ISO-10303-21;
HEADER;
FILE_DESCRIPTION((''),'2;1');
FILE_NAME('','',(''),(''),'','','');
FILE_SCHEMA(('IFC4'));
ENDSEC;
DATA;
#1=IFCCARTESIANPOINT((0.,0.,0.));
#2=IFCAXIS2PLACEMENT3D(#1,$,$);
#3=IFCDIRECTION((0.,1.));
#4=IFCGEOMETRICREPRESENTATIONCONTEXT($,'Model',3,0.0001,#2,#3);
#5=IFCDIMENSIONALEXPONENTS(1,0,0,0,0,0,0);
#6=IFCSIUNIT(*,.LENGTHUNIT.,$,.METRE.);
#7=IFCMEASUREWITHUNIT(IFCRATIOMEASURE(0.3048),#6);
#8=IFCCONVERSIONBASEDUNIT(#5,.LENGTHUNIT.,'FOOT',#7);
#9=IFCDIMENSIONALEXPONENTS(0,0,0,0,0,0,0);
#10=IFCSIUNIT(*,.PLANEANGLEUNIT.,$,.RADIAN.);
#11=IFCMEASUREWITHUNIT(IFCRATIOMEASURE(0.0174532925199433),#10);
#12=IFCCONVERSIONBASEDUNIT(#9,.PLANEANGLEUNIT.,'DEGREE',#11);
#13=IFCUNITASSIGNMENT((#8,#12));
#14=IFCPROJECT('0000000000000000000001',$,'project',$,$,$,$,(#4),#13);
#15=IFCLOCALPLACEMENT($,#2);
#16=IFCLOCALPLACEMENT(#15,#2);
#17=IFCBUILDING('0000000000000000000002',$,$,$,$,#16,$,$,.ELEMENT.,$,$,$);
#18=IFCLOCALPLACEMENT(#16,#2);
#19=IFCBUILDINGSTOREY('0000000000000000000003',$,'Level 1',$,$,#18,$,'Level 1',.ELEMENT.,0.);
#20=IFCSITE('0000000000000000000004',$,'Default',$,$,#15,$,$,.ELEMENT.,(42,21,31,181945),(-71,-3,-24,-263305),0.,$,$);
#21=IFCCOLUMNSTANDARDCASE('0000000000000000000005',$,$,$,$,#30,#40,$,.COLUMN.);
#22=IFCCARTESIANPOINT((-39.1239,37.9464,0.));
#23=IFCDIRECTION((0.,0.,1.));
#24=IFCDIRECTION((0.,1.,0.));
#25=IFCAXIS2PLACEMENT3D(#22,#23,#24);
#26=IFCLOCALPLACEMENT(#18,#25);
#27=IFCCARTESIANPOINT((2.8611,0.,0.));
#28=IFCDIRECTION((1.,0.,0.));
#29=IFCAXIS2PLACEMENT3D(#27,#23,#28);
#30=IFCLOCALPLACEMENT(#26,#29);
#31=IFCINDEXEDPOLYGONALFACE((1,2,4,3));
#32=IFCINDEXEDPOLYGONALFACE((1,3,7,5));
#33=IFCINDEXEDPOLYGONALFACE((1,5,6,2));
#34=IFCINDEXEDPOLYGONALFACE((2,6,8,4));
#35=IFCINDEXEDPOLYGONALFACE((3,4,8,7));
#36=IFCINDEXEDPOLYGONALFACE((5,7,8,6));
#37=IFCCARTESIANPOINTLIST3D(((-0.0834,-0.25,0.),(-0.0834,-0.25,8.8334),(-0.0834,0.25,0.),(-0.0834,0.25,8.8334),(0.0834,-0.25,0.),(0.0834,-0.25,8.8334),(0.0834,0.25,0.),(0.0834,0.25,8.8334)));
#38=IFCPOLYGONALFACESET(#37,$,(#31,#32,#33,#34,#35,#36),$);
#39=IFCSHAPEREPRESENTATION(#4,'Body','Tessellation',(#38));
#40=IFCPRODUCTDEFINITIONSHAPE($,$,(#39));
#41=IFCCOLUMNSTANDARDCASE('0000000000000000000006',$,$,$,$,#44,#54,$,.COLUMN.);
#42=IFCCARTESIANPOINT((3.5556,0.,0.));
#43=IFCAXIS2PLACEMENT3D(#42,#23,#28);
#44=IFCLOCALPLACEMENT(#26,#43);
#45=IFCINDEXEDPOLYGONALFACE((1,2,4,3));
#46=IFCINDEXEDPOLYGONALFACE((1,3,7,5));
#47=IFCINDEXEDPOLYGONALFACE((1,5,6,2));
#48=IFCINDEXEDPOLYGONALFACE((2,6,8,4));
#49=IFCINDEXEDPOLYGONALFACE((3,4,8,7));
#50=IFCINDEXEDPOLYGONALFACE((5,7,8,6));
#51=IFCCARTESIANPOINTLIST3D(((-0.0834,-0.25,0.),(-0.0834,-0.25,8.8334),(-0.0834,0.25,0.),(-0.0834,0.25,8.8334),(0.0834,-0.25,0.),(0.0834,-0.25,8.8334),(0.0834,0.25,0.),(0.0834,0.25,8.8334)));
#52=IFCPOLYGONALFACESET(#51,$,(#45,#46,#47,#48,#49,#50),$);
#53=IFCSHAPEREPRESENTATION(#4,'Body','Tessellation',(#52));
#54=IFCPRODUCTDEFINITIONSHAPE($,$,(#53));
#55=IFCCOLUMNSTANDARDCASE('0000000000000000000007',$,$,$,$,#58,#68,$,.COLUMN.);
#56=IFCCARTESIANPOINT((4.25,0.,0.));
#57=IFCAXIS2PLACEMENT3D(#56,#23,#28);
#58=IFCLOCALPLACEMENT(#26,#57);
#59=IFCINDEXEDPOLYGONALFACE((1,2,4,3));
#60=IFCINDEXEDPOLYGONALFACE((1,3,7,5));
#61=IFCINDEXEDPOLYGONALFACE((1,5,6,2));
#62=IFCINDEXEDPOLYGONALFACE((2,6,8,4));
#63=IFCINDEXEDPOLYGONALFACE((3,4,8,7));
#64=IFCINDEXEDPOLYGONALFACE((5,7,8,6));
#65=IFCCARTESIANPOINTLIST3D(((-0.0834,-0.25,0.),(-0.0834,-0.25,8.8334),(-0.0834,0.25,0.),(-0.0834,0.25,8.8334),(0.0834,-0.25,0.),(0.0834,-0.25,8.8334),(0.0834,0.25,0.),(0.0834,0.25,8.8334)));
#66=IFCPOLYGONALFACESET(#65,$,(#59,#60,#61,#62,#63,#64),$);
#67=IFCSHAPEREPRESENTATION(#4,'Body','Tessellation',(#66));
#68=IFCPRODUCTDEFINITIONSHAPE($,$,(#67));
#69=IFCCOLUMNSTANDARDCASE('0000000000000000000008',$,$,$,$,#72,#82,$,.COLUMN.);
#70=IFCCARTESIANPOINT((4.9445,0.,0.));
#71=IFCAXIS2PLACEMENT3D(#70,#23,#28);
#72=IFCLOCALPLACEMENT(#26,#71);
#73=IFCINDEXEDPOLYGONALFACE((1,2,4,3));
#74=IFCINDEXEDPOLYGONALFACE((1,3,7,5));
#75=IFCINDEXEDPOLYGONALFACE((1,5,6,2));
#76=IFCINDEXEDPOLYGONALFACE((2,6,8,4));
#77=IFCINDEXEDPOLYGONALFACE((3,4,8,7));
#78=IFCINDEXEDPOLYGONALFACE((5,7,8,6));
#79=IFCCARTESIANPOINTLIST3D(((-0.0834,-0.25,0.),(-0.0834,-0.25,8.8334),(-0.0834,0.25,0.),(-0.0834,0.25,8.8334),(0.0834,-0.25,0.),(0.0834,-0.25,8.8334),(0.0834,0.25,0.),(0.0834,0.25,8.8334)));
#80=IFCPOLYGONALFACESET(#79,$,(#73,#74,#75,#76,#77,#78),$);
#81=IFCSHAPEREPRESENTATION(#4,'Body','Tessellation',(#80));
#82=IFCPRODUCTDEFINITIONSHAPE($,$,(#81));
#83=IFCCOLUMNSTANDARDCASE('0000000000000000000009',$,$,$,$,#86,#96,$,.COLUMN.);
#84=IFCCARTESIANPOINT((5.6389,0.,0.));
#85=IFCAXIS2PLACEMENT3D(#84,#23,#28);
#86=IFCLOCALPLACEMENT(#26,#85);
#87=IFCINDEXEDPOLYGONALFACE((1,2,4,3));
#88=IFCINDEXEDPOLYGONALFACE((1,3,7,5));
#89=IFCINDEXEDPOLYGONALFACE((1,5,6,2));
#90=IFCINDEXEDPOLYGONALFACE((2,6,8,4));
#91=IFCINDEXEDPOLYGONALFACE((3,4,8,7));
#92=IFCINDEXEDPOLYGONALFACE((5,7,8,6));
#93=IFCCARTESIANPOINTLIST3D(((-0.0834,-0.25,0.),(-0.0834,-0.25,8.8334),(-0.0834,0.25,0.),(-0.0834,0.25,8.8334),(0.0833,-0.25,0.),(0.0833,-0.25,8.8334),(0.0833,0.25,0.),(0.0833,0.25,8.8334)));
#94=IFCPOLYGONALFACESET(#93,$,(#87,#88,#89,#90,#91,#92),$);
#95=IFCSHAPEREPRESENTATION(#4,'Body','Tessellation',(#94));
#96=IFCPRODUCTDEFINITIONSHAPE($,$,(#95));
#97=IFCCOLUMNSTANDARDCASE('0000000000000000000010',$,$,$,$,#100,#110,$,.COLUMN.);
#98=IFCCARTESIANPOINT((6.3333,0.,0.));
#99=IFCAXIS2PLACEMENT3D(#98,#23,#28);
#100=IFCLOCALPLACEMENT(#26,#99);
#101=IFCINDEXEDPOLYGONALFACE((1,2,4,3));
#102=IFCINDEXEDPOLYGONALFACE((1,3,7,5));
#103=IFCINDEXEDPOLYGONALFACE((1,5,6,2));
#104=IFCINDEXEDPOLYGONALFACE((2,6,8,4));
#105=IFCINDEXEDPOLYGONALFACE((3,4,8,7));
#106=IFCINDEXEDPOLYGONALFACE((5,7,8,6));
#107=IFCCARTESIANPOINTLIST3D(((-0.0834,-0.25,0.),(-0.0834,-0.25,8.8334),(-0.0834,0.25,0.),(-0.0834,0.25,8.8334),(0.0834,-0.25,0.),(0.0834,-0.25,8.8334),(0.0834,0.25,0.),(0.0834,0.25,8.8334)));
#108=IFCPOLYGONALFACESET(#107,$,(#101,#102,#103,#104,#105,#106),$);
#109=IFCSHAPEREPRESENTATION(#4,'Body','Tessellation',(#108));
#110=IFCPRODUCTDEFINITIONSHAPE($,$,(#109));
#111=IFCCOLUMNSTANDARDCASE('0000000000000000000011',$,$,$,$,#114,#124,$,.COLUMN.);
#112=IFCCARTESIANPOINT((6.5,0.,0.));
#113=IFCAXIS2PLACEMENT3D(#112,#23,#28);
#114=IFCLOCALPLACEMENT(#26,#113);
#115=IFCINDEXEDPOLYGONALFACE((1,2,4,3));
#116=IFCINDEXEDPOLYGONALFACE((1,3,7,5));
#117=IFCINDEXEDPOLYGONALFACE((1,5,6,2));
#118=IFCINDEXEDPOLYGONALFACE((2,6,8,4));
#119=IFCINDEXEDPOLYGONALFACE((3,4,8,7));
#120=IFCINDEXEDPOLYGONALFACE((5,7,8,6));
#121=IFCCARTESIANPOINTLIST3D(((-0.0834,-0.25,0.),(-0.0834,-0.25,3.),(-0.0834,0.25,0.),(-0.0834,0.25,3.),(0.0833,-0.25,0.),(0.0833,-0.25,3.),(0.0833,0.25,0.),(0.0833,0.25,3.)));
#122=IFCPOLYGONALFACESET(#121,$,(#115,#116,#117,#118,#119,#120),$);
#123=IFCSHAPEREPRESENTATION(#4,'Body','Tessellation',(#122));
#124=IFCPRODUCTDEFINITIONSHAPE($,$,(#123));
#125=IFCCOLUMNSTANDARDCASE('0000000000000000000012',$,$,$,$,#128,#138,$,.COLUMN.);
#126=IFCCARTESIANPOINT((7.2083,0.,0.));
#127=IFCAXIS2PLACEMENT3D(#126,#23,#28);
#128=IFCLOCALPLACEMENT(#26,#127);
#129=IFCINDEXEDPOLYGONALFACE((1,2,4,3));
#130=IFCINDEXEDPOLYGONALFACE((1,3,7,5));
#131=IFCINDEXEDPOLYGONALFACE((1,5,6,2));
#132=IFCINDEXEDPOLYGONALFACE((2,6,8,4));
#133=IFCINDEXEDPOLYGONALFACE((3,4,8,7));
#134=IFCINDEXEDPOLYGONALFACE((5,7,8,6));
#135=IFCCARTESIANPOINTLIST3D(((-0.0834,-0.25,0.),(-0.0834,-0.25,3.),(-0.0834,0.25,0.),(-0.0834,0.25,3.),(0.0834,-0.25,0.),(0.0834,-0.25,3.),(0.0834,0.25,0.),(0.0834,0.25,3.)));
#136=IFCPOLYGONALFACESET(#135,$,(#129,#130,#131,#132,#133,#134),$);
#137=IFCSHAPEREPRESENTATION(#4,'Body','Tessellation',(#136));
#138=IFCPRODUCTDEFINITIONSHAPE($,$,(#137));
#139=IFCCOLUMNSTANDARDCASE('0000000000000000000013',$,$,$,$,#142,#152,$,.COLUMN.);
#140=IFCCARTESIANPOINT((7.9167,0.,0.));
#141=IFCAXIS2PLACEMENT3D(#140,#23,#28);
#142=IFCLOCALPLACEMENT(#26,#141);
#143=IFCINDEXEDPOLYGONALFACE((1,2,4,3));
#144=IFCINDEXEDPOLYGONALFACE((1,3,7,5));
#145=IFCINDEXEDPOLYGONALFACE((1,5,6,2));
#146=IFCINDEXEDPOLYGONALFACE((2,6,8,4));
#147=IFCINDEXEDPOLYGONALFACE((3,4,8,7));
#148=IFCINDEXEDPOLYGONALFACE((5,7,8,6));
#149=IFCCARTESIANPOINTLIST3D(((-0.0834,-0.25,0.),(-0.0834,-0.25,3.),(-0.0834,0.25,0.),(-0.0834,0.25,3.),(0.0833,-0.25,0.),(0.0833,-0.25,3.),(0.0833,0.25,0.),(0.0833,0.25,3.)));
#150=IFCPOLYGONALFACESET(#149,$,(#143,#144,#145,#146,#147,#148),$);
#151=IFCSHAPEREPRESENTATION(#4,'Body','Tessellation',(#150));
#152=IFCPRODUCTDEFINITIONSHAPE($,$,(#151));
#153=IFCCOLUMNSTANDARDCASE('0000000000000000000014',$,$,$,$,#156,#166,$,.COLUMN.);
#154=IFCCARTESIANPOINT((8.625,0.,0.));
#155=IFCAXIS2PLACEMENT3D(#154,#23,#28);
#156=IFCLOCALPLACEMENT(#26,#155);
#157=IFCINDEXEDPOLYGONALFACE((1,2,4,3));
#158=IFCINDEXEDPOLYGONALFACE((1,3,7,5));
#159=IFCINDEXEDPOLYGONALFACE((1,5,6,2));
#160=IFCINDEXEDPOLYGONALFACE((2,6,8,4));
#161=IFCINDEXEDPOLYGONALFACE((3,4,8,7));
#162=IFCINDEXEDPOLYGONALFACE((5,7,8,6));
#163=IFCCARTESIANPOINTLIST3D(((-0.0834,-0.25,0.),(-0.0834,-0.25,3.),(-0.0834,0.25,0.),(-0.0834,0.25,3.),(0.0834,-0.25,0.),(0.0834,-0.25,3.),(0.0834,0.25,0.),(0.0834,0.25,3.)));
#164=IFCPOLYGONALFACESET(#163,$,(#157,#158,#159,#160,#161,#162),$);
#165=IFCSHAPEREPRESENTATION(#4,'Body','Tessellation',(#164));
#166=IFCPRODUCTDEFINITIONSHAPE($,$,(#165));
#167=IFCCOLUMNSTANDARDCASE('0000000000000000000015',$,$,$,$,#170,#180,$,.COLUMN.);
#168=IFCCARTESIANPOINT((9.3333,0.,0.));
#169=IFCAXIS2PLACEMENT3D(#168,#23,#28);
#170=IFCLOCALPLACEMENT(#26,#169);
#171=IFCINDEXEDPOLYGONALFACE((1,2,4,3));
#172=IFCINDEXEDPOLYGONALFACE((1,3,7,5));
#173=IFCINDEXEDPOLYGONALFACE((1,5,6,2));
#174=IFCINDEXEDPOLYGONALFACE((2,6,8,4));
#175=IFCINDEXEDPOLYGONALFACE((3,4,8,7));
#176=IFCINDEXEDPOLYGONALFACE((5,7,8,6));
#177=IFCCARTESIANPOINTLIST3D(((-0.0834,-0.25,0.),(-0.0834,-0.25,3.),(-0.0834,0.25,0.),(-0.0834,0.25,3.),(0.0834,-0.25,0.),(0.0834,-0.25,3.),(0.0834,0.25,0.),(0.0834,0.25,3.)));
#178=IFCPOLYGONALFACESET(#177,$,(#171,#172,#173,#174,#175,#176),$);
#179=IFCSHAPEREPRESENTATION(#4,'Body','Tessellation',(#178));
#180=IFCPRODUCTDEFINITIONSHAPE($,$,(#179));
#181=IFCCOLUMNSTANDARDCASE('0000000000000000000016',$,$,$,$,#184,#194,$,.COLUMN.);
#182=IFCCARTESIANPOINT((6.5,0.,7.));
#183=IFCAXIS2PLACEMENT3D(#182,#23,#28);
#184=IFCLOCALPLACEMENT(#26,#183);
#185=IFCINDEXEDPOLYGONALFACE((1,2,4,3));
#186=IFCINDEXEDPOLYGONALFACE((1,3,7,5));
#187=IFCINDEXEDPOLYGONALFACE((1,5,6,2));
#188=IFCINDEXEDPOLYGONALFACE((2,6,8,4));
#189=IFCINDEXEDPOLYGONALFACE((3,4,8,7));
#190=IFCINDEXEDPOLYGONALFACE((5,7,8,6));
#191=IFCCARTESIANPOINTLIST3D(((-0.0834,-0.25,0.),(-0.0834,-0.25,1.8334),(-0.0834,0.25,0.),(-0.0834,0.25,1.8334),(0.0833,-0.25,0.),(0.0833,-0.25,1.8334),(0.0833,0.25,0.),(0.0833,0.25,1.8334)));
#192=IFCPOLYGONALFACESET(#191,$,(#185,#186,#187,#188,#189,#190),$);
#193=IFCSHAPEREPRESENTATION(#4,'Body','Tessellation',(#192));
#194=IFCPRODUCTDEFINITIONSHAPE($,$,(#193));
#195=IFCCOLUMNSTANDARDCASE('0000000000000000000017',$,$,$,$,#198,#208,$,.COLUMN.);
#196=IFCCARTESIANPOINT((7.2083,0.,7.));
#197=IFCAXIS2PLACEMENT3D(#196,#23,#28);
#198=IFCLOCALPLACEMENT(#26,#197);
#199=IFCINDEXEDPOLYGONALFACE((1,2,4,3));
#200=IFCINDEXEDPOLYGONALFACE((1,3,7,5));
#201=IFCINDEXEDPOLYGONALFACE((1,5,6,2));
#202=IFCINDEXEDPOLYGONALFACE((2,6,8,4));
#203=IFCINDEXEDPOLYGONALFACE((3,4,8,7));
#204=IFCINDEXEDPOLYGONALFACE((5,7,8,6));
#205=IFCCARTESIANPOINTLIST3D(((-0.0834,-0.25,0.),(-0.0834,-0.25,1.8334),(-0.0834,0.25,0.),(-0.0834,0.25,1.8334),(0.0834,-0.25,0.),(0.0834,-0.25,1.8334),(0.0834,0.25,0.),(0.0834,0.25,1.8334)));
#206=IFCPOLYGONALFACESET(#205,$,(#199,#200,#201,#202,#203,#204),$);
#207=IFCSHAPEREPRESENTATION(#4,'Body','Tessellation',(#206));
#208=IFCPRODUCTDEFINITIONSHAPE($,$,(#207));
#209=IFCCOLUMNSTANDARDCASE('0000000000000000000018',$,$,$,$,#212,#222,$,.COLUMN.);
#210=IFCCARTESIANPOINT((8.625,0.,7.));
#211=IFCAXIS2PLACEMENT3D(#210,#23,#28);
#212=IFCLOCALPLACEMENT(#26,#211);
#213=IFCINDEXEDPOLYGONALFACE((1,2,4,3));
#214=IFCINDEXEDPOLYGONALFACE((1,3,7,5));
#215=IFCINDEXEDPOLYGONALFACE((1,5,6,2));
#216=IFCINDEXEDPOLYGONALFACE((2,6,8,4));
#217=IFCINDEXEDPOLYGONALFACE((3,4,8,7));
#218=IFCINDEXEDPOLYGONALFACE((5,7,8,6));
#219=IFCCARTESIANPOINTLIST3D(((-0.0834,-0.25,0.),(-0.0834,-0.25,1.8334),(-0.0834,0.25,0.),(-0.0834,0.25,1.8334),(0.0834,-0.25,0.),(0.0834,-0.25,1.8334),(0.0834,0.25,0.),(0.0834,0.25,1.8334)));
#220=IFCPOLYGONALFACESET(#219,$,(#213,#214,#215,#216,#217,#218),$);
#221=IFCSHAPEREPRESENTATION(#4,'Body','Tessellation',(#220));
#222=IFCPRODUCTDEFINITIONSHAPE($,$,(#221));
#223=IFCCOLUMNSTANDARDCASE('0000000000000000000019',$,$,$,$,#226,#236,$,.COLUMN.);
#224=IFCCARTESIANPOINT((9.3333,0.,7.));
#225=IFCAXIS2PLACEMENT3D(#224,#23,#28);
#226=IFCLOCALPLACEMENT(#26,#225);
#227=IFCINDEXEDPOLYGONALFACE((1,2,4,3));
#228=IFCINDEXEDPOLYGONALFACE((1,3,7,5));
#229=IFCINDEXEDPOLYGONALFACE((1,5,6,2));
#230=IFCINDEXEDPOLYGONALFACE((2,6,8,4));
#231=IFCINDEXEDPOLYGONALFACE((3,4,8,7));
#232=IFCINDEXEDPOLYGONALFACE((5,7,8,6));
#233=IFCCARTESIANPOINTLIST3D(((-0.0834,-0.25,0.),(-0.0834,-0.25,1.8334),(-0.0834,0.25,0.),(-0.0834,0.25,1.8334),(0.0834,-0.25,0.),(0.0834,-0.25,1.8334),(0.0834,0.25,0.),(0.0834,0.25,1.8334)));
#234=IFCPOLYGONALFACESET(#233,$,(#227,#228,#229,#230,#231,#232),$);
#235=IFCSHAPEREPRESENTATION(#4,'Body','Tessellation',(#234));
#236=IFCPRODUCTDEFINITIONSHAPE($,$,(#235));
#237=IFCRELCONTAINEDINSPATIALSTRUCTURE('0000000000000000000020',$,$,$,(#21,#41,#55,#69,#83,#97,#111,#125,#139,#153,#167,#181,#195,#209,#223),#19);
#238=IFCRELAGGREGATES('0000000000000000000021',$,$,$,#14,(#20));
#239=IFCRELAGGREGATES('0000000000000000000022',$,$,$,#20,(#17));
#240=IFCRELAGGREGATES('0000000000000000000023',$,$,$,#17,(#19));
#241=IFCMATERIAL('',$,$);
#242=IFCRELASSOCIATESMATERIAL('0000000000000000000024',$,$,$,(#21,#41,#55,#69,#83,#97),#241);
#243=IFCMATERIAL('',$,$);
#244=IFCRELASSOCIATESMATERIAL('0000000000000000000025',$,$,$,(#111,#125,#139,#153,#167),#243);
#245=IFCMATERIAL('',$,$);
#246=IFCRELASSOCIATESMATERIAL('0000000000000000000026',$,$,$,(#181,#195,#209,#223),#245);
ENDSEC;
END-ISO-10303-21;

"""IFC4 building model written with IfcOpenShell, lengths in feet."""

from ifc_helpers import new_model, entity, si_unit, converted_unit, direction, frame, origin, place, context, project, spatial, rectangle, extrude, material, element, save


model = new_model("IFC4")

# Units and contexts
model_context = context("Model", 3, precision=0.0001, world=origin(), true_north=direction((0.0, 1.0)))
ifc_project = project(units=[converted_unit("LENGTHUNIT", "FOOT", entity("IfcRatioMeasure", 0.3048), si_unit("LENGTHUNIT", "METRE"), dimensions=[1, 0, 0, 0, 0, 0, 0]), converted_unit("PLANEANGLEUNIT", "DEGREE", entity("IfcRatioMeasure", 0.0174532925199433), si_unit("PLANEANGLEUNIT", "RADIAN"), dimensions=[0, 0, 0, 0, 0, 0, 0])], contexts=[model_context])

# Site, building, storey
site_placement = place(None, origin())
site = spatial("IfcSite", under=ifc_project, at=site_placement, Name="Default", CompositionType="ELEMENT", RefLatitude=(42, 21, 31, 181945), RefLongitude=(-71, -3, -24, -263305), RefElevation=0.0)
building_placement = place(site_placement, origin())
building = spatial("IfcBuilding", under=site, at=building_placement, CompositionType="ELEMENT")
storey_placement = place(building_placement, origin())
storey = spatial("IfcBuildingStorey", under=building, at=storey_placement, Name="Level 1", LongName="Level 1", CompositionType="ELEMENT", Elevation=0.0)

# Columns
ifc_material_1 = material(Name="")
placement_1 = place(storey_placement, frame((-39.1239, 37.9464, 0.0), z_axis=(0.0, 0.0, 1.0), x_axis=(0.0, 1.0, 0.0)))
for number, where, z_axis, x_axis in (
    (1, (2.8611, 0.0, 0.0), (0.0, 0.0, 1.0), (1.0, 0.0, 0.0)),
    (2, (3.5556, 0.0, 0.0), (0.0, 0.0, 1.0), (1.0, 0.0, 0.0)),
    (3, (4.25, 0.0, 0.0), (0.0, 0.0, 1.0), (1.0, 0.0, 0.0)),
    (4, (4.9445, 0.0, 0.0), (0.0, 0.0, 1.0), (1.0, 0.0, 0.0)),
    (5, (5.6389, 0.0, 0.0), (0.0, 0.0, 1.0), (1.0, 0.0, 0.0)),
    (6, (6.3333, 0.0, 0.0), (0.0, 0.0, 1.0), (1.0, 0.0, 0.0)),
):
    element("IfcColumnStandardCase", number, at=place(placement_1, frame(where, z_axis=z_axis, x_axis=x_axis)), inside=storey, material=ifc_material_1, PredefinedType="COLUMN", context=model_context, shape_type="SweptSolid", body=[
        extrude(rectangle(XDim=0.1667, YDim=0.5), origin(), (0.0, 0.0, 1.0), 8.8334),
    ])
ifc_material_2 = material(Name="")
for number, where, z_axis, x_axis in (
    (7, (6.5, 0.0, 0.0), (0.0, 0.0, 1.0), (1.0, 0.0, 0.0)),
    (8, (7.2083, 0.0, 0.0), (0.0, 0.0, 1.0), (1.0, 0.0, 0.0)),
    (9, (7.9167, 0.0, 0.0), (0.0, 0.0, 1.0), (1.0, 0.0, 0.0)),
    (10, (8.625, 0.0, 0.0), (0.0, 0.0, 1.0), (1.0, 0.0, 0.0)),
    (11, (9.3333, 0.0, 0.0), (0.0, 0.0, 1.0), (1.0, 0.0, 0.0)),
):
    element("IfcColumnStandardCase", number, at=place(placement_1, frame(where, z_axis=z_axis, x_axis=x_axis)), inside=storey, material=ifc_material_2, PredefinedType="COLUMN", context=model_context, shape_type="SweptSolid", body=[
        extrude(rectangle(XDim=0.1667, YDim=0.5), origin(), (0.0, 0.0, 1.0), 3.0),
    ])
ifc_material_3 = material(Name="")
for number, where, z_axis, x_axis in (
    (12, (6.5, 0.0, 7.0), (0.0, 0.0, 1.0), (1.0, 0.0, 0.0)),
    (13, (7.2083, 0.0, 7.0), (0.0, 0.0, 1.0), (1.0, 0.0, 0.0)),
    (14, (8.625, 0.0, 7.0), (0.0, 0.0, 1.0), (1.0, 0.0, 0.0)),
    (15, (9.3333, 0.0, 7.0), (0.0, 0.0, 1.0), (1.0, 0.0, 0.0)),
):
    element("IfcColumnStandardCase", number, at=place(placement_1, frame(where, z_axis=z_axis, x_axis=x_axis)), inside=storey, material=ifc_material_3, PredefinedType="COLUMN", context=model_context, shape_type="SweptSolid", body=[
        extrude(rectangle(XDim=0.1667, YDim=0.5), origin(), (0.0, 0.0, 1.0), 1.8334),
    ])

save(model, "model.ifc")
